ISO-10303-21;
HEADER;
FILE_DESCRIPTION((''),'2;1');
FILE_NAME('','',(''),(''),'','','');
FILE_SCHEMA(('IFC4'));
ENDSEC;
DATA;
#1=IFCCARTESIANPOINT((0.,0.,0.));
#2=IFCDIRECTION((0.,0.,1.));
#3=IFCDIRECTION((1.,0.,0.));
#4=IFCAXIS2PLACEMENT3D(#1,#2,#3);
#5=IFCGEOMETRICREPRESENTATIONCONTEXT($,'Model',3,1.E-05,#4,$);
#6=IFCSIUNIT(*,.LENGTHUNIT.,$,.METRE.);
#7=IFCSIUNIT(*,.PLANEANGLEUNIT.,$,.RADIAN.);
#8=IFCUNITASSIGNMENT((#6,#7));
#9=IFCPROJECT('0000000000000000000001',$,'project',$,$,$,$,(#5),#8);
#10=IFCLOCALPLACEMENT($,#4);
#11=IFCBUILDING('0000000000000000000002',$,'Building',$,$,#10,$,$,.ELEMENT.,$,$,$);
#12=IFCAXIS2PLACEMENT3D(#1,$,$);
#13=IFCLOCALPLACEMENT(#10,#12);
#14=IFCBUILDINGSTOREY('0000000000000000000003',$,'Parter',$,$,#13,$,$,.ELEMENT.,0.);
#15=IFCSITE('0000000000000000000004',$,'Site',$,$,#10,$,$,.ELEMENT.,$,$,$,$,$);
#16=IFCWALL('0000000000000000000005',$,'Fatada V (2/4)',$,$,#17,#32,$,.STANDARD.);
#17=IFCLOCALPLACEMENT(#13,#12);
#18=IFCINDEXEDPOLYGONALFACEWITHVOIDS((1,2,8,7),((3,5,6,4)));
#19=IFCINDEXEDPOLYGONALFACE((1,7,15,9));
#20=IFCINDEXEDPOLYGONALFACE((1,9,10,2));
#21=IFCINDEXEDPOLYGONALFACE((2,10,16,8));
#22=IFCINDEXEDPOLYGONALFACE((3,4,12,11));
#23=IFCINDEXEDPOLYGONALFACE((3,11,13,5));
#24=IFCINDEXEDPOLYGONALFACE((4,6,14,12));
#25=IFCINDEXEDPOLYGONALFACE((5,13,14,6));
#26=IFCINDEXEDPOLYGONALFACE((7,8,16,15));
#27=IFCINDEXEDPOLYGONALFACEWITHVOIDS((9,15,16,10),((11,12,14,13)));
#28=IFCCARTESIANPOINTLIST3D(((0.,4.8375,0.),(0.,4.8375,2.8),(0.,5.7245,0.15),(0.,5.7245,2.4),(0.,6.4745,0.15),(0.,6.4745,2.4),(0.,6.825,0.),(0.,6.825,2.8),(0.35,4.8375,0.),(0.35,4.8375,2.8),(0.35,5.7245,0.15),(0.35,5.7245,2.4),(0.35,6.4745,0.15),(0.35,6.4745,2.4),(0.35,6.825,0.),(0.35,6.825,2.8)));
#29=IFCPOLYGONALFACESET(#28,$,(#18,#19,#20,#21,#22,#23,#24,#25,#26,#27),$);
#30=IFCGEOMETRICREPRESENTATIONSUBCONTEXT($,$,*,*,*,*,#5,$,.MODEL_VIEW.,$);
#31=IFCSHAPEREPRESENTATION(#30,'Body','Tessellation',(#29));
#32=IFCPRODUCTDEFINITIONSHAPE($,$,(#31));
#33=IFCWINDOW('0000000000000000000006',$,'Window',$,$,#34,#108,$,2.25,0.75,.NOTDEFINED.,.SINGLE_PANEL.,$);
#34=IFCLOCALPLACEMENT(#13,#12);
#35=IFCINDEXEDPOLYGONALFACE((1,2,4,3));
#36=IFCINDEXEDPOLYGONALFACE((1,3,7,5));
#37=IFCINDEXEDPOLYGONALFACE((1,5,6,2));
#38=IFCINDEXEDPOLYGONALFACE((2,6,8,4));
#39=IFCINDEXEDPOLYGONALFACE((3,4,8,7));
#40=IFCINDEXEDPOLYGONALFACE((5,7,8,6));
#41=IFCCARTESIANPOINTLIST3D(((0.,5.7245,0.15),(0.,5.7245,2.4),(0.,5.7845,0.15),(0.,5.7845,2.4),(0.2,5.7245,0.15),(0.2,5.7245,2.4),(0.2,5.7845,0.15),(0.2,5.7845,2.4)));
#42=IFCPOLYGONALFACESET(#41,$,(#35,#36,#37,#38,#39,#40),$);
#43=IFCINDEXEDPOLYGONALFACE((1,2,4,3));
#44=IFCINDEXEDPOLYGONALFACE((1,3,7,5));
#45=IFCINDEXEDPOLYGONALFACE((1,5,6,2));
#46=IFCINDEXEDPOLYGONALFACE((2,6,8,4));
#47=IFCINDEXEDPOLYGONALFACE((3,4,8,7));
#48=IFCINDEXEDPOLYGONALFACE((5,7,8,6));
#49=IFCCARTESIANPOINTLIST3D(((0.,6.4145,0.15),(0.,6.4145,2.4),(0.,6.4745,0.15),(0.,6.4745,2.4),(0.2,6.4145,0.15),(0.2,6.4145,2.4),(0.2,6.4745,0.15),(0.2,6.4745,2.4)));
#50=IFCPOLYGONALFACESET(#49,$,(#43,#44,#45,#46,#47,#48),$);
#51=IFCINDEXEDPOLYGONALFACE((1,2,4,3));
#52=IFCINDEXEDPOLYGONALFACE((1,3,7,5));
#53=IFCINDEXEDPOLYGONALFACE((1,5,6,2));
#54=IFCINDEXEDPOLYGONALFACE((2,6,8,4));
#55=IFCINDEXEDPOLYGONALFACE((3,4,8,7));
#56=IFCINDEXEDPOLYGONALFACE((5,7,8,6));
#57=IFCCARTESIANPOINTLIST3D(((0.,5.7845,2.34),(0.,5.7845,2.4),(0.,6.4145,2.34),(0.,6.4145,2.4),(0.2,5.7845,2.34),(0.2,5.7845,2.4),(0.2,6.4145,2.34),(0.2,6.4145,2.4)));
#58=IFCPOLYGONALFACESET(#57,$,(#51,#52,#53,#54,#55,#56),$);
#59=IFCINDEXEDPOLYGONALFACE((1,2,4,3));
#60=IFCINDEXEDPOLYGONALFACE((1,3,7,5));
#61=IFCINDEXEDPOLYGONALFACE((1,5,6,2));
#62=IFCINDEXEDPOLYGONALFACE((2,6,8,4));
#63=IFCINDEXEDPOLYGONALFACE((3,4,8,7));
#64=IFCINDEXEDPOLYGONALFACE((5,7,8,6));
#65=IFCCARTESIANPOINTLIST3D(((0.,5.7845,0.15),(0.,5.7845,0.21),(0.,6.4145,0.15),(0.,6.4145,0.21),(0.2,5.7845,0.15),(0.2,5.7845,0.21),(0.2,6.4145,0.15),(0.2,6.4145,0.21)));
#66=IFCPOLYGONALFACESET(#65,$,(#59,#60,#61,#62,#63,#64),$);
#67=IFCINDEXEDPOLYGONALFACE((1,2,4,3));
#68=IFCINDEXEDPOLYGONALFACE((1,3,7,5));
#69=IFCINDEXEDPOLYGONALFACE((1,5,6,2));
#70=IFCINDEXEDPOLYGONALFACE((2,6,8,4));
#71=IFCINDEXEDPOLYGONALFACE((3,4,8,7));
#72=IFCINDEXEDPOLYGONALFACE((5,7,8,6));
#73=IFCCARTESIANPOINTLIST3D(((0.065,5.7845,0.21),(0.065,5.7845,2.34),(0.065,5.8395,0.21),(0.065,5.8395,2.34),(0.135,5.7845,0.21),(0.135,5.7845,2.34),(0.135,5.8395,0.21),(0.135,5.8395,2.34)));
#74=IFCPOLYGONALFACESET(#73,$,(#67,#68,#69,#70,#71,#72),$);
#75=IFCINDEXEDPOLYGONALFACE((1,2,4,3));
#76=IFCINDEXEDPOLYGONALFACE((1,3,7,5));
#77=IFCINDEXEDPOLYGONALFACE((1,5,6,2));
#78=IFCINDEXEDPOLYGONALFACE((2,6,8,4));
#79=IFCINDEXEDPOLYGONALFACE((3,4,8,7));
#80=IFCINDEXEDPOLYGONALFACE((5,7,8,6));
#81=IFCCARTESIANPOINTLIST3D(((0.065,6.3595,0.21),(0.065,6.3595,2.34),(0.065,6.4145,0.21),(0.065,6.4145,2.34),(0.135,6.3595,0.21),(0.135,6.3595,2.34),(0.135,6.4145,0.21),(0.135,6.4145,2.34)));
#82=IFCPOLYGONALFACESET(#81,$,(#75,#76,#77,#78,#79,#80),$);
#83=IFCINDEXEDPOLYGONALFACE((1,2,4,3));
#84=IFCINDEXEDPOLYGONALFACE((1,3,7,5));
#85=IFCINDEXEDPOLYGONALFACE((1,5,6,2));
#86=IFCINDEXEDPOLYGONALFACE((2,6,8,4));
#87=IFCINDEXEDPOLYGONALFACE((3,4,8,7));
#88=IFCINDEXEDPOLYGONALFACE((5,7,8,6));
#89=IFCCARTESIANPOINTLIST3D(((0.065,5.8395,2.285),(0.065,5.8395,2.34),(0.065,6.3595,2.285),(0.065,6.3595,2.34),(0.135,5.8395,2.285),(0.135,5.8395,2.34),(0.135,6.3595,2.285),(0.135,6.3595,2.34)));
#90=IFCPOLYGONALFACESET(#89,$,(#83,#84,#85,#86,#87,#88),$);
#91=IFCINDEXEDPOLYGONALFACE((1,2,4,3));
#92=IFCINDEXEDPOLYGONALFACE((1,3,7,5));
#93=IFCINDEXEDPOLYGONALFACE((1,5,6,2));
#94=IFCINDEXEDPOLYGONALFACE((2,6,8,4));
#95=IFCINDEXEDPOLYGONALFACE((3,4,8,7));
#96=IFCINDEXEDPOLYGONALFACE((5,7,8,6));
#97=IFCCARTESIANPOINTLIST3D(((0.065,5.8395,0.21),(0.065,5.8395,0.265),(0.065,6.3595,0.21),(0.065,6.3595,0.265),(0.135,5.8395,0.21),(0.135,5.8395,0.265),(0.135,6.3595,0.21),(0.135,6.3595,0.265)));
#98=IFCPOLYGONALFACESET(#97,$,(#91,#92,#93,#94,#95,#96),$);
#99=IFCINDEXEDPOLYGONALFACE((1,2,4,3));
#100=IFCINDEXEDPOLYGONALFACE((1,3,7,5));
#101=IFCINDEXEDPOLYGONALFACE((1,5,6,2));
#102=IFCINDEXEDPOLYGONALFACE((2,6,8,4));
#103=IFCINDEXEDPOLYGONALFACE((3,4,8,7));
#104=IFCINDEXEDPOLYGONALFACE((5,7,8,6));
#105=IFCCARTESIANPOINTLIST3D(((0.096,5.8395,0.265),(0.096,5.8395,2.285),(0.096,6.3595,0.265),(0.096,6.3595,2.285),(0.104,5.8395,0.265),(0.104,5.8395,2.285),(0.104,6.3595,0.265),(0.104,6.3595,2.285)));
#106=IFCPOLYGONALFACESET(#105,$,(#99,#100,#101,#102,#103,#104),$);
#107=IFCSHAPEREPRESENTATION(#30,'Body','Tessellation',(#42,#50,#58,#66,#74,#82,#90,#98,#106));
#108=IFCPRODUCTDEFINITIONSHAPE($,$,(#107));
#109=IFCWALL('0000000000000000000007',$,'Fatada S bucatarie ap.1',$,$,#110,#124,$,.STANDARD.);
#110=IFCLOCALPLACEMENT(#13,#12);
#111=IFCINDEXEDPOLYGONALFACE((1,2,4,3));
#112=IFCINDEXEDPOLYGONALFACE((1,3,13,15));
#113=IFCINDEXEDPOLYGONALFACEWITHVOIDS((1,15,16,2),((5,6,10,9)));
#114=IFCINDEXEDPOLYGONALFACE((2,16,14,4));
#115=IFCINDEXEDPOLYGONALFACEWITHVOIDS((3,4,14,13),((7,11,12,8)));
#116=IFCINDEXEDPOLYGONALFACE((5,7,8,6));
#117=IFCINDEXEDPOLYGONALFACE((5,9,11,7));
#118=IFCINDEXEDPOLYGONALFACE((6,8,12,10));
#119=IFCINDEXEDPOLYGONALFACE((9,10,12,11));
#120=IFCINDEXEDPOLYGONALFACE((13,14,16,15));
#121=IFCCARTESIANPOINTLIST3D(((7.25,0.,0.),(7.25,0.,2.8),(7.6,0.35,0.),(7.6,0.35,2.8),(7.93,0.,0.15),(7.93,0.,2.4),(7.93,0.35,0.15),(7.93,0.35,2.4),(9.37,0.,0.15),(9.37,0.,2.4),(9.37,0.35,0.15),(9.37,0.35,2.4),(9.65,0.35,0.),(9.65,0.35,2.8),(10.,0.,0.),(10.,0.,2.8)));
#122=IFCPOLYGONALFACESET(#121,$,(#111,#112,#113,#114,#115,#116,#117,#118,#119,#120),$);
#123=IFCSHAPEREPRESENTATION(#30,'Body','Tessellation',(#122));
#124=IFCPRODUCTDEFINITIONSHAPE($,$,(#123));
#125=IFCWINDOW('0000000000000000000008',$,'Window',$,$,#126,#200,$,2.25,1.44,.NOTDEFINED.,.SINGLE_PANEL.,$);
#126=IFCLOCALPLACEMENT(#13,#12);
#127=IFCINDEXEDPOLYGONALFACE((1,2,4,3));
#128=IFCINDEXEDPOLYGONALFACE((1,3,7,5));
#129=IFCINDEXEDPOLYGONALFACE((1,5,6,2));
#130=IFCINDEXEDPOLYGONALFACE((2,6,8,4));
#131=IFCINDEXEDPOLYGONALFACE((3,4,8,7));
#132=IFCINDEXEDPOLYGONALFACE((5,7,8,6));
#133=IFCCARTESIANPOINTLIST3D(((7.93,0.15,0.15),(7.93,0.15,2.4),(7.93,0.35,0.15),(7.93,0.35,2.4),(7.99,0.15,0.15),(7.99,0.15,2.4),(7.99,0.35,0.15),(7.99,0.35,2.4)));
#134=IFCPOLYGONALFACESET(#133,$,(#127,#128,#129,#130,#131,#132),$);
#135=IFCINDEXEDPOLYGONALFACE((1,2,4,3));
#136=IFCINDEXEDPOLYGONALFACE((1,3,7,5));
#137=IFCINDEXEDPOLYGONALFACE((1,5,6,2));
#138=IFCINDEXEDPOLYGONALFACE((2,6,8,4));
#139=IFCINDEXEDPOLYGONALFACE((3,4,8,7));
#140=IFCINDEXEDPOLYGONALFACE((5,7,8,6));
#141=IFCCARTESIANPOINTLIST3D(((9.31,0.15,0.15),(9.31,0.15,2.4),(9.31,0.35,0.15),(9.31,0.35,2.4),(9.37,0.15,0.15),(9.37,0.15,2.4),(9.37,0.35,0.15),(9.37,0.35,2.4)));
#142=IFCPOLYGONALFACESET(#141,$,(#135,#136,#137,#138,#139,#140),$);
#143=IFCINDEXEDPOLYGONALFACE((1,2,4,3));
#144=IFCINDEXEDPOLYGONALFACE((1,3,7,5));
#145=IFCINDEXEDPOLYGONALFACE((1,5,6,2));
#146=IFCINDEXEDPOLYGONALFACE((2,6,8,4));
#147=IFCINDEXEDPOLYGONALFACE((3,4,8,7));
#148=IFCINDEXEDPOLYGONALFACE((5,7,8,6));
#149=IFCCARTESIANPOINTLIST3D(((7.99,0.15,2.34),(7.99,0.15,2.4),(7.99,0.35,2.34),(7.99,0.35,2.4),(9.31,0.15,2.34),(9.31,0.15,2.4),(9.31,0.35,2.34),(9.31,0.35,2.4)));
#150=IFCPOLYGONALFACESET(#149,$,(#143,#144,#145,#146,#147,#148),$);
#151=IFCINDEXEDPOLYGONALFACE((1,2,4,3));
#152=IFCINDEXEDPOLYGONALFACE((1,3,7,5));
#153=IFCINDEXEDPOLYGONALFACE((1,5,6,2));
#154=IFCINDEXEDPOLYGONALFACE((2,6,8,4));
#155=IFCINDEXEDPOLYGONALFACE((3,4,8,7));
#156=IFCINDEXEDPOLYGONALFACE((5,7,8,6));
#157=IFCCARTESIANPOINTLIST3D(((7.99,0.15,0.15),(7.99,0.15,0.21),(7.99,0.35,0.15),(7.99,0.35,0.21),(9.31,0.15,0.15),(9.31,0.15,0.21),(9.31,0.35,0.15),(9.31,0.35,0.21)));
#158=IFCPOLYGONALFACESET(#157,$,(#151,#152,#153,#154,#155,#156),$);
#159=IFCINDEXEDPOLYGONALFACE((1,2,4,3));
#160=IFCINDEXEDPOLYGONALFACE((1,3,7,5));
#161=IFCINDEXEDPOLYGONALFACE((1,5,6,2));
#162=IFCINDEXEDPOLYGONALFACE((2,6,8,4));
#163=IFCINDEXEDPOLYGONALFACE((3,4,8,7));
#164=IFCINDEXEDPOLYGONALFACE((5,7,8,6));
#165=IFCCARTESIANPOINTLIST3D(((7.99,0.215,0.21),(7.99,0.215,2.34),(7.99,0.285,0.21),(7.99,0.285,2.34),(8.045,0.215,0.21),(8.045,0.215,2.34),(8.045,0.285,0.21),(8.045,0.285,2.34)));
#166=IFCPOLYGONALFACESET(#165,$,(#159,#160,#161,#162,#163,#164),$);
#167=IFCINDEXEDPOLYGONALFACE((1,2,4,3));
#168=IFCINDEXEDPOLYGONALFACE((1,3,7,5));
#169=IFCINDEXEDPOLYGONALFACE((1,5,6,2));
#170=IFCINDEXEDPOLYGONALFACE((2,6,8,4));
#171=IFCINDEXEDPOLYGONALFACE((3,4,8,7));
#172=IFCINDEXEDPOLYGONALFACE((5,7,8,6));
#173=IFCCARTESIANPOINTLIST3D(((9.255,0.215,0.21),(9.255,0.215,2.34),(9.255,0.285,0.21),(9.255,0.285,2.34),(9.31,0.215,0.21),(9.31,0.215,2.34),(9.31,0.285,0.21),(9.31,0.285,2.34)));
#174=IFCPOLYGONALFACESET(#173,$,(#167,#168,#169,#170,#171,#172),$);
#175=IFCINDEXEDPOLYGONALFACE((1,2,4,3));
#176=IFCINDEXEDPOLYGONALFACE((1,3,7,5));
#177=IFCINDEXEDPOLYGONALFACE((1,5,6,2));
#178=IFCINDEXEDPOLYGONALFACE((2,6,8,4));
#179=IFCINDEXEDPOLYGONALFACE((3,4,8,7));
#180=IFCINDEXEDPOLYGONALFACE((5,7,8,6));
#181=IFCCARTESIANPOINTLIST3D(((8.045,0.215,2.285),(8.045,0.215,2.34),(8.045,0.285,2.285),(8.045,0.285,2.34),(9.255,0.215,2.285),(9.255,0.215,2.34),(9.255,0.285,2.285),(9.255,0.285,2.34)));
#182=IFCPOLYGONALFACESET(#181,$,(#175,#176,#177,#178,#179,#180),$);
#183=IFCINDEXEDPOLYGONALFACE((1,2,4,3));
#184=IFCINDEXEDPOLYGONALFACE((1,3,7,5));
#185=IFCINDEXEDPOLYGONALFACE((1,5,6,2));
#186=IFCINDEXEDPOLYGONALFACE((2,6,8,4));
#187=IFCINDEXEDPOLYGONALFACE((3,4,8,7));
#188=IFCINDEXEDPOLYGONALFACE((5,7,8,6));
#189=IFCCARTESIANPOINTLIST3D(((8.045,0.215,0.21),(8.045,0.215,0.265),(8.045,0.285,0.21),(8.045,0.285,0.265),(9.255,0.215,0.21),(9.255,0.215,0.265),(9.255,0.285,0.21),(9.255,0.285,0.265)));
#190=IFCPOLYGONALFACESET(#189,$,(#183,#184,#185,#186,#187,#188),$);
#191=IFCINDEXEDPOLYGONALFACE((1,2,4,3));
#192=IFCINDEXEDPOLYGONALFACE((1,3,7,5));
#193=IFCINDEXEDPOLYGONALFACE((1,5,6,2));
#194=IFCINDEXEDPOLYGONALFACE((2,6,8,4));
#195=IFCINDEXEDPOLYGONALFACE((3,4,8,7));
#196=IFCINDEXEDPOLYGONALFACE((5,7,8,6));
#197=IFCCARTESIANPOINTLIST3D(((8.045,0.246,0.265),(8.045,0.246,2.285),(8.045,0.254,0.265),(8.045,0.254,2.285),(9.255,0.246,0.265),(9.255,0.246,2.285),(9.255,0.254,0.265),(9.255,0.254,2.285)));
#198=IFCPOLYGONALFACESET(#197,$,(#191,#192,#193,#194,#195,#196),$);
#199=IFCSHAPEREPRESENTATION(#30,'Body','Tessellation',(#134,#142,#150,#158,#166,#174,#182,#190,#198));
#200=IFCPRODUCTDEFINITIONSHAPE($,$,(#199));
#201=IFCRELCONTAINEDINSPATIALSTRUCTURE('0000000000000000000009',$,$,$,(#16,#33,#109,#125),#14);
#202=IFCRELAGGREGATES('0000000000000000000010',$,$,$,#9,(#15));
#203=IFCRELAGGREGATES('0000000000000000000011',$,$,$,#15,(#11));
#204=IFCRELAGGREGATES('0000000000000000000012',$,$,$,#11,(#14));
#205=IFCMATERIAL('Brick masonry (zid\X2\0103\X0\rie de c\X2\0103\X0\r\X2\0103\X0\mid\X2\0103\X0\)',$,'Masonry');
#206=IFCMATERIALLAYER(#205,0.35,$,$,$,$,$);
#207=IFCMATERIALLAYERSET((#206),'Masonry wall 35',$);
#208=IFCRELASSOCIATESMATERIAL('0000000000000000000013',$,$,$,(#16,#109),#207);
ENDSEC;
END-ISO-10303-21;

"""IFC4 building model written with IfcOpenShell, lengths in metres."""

from ifc_helpers import new_model, si_unit, frame, frame_2d, origin, origin_with_axes, origin_2d, place, context, subcontext, project, spatial, rectangle, extrude, clip, halfspace, material, layer, layer_set, layer_usage, element, fill, save


model = new_model("IFC4")

# Units and contexts
model_context = context("Model", 3, precision=1e-05, world=origin_with_axes())
sub_context = subcontext(model_context, None, None, "MODEL_VIEW")
ifc_project = project(units=[si_unit("LENGTHUNIT", "METRE"), si_unit("PLANEANGLEUNIT", "RADIAN")], contexts=[model_context])

# Site, building, storey
placement = place(None, origin_with_axes())
site = spatial("IfcSite", under=ifc_project, at=placement, Name="Site", CompositionType="ELEMENT")
building = spatial("IfcBuilding", under=site, at=placement, Name="Building", CompositionType="ELEMENT")
storey_placement = place(placement, origin())
storey = spatial("IfcBuildingStorey", under=building, at=storey_placement, Name="Parter", CompositionType="ELEMENT", Elevation=0.0)

# Walls, openings, windows
ifc_material_1 = material(Name="Brick masonry (zidărie de cărămidă)", Category="Masonry")
ifc_layer_1 = layer(ifc_material_1, 0.35)
ifc_layer_set_1 = layer_set([ifc_layer_1], Name="Masonry wall 35")
ifc_layer_usage_1 = layer_usage(ifc_layer_set_1, "AXIS2", "POSITIVE", -0.175)
wall_1_placement = place(storey_placement, frame((0.175, 4.8375, 0.0), x_axis=(0.0, 1.0, 0.0)))
wall_1 = element("IfcWall", 1, at=wall_1_placement, inside=storey, material=ifc_layer_usage_1, Name="Fatada V (2/4)", PredefinedType="STANDARD", context=sub_context, shape_type="SweptSolid", body=[
    extrude(rectangle(XDim=1.9875, YDim=0.35, at=frame_2d((0.9937, 0.0))), origin(), (0.0, 0.0, 1.0), 2.8),
])
opening_1_placement = place(wall_1_placement, frame((1.262, 0.225, 0.15), z_axis=(0.0, -1.0, 0.0), x_axis=(1.0, 0.0, 0.0)))
opening_1 = element("IfcOpeningElement", 2, at=opening_1_placement, cuts=wall_1, PredefinedType="OPENING", context=sub_context, shape_type="SweptSolid", body=[
    extrude(rectangle(XDim=0.75, YDim=2.25, at=frame_2d((0.0, 1.125))), origin(), (0.0, 0.0, 1.0), 0.45),
])
window_1_placement = place(wall_1_placement, frame((1.262, 0.175, 0.15), z_axis=(0.0, -1.0, 0.0), x_axis=(1.0, 0.0, 0.0)))
window_1 = element("IfcWindow", 3, at=window_1_placement, inside=storey, Name="Window", OverallHeight=2.25, OverallWidth=0.75, PartitioningType="SINGLE_PANEL", PredefinedType="NOTDEFINED", context=sub_context, shape_type="SweptSolid", body=[
    extrude(rectangle(XDim=0.06, YDim=2.25, at=origin_2d()), frame((-0.345, 1.125, 0.0)), (0.0, 0.0, 1.0), 0.2),
    extrude(rectangle(XDim=0.06, YDim=2.25, at=origin_2d()), frame((0.345, 1.125, 0.0)), (0.0, 0.0, 1.0), 0.2),
    extrude(rectangle(XDim=0.63, YDim=0.06, at=origin_2d()), frame((0.0, 2.22, 0.0)), (0.0, 0.0, 1.0), 0.2),
    extrude(rectangle(XDim=0.63, YDim=0.06, at=origin_2d()), frame((0.0, 0.03, 0.0)), (0.0, 0.0, 1.0), 0.2),
    extrude(rectangle(XDim=0.055, YDim=2.13, at=origin_2d()), frame((-0.2875, 1.125, 0.065)), (0.0, 0.0, 1.0), 0.07),
    extrude(rectangle(XDim=0.055, YDim=2.13, at=origin_2d()), frame((0.2875, 1.125, 0.065)), (0.0, 0.0, 1.0), 0.07),
    extrude(rectangle(XDim=0.52, YDim=0.055, at=origin_2d()), frame((0.0, 2.1625, 0.065)), (0.0, 0.0, 1.0), 0.07),
    extrude(rectangle(XDim=0.52, YDim=0.055, at=origin_2d()), frame((0.0, 0.0875, 0.065)), (0.0, 0.0, 1.0), 0.07),
    extrude(rectangle(XDim=0.52, YDim=2.02, at=origin_2d()), frame((0.0, 1.125, 0.096)), (0.0, 0.0, 1.0), 0.008),
])
fill(opening_1, window_1)
wall_2_placement = place(storey_placement, frame((7.25, 0.175, 0.0), x_axis=(1.0, 0.0, 0.0)))
wall_2 = element("IfcWall", 4, at=wall_2_placement, inside=storey, material=ifc_layer_usage_1, Name="Fatada S bucatarie ap.1", PredefinedType="STANDARD", context=sub_context, shape_type="CSG", body=[
    clip(clip(extrude(rectangle(XDim=2.75, YDim=0.35, at=frame_2d((1.375, 0.0))), origin(), (0.0, 0.0, 1.0), 2.8), halfspace(frame((0.175, 0.0, 0.0), z_axis=(-0.707107, 0.707107, 0.0)), False)), halfspace(frame((2.575, 0.0, 0.0), z_axis=(0.707107, 0.707107, 0.0)), False)),
])
opening_2_placement = place(wall_2_placement, frame((1.4, 0.225, 0.15), z_axis=(0.0, -1.0, 0.0), x_axis=(1.0, 0.0, 0.0)))
opening_2 = element("IfcOpeningElement", 5, at=opening_2_placement, cuts=wall_2, PredefinedType="OPENING", context=sub_context, shape_type="SweptSolid", body=[
    extrude(rectangle(XDim=1.44, YDim=2.25, at=frame_2d((0.0, 1.125))), origin(), (0.0, 0.0, 1.0), 0.45),
])
window_2_placement = place(wall_2_placement, frame((1.4, 0.175, 0.15), z_axis=(0.0, -1.0, 0.0), x_axis=(1.0, 0.0, 0.0)))
window_2 = element("IfcWindow", 6, at=window_2_placement, inside=storey, Name="Window", OverallHeight=2.25, OverallWidth=1.44, PartitioningType="SINGLE_PANEL", PredefinedType="NOTDEFINED", context=sub_context, shape_type="SweptSolid", body=[
    extrude(rectangle(XDim=0.06, YDim=2.25, at=origin_2d()), frame((-0.69, 1.125, 0.0)), (0.0, 0.0, 1.0), 0.2),
    extrude(rectangle(XDim=0.06, YDim=2.25, at=origin_2d()), frame((0.69, 1.125, 0.0)), (0.0, 0.0, 1.0), 0.2),
    extrude(rectangle(XDim=1.32, YDim=0.06, at=origin_2d()), frame((0.0, 2.22, 0.0)), (0.0, 0.0, 1.0), 0.2),
    extrude(rectangle(XDim=1.32, YDim=0.06, at=origin_2d()), frame((0.0, 0.03, 0.0)), (0.0, 0.0, 1.0), 0.2),
    extrude(rectangle(XDim=0.055, YDim=2.13, at=origin_2d()), frame((-0.6325, 1.125, 0.065)), (0.0, 0.0, 1.0), 0.07),
    extrude(rectangle(XDim=0.055, YDim=2.13, at=origin_2d()), frame((0.6325, 1.125, 0.065)), (0.0, 0.0, 1.0), 0.07),
    extrude(rectangle(XDim=1.21, YDim=0.055, at=origin_2d()), frame((0.0, 2.1625, 0.065)), (0.0, 0.0, 1.0), 0.07),
    extrude(rectangle(XDim=1.21, YDim=0.055, at=origin_2d()), frame((0.0, 0.0875, 0.065)), (0.0, 0.0, 1.0), 0.07),
    extrude(rectangle(XDim=1.21, YDim=2.02, at=origin_2d()), frame((0.0, 1.125, 0.096)), (0.0, 0.0, 1.0), 0.008),
])
fill(opening_2, window_2)

save(model, "model.ifc")
